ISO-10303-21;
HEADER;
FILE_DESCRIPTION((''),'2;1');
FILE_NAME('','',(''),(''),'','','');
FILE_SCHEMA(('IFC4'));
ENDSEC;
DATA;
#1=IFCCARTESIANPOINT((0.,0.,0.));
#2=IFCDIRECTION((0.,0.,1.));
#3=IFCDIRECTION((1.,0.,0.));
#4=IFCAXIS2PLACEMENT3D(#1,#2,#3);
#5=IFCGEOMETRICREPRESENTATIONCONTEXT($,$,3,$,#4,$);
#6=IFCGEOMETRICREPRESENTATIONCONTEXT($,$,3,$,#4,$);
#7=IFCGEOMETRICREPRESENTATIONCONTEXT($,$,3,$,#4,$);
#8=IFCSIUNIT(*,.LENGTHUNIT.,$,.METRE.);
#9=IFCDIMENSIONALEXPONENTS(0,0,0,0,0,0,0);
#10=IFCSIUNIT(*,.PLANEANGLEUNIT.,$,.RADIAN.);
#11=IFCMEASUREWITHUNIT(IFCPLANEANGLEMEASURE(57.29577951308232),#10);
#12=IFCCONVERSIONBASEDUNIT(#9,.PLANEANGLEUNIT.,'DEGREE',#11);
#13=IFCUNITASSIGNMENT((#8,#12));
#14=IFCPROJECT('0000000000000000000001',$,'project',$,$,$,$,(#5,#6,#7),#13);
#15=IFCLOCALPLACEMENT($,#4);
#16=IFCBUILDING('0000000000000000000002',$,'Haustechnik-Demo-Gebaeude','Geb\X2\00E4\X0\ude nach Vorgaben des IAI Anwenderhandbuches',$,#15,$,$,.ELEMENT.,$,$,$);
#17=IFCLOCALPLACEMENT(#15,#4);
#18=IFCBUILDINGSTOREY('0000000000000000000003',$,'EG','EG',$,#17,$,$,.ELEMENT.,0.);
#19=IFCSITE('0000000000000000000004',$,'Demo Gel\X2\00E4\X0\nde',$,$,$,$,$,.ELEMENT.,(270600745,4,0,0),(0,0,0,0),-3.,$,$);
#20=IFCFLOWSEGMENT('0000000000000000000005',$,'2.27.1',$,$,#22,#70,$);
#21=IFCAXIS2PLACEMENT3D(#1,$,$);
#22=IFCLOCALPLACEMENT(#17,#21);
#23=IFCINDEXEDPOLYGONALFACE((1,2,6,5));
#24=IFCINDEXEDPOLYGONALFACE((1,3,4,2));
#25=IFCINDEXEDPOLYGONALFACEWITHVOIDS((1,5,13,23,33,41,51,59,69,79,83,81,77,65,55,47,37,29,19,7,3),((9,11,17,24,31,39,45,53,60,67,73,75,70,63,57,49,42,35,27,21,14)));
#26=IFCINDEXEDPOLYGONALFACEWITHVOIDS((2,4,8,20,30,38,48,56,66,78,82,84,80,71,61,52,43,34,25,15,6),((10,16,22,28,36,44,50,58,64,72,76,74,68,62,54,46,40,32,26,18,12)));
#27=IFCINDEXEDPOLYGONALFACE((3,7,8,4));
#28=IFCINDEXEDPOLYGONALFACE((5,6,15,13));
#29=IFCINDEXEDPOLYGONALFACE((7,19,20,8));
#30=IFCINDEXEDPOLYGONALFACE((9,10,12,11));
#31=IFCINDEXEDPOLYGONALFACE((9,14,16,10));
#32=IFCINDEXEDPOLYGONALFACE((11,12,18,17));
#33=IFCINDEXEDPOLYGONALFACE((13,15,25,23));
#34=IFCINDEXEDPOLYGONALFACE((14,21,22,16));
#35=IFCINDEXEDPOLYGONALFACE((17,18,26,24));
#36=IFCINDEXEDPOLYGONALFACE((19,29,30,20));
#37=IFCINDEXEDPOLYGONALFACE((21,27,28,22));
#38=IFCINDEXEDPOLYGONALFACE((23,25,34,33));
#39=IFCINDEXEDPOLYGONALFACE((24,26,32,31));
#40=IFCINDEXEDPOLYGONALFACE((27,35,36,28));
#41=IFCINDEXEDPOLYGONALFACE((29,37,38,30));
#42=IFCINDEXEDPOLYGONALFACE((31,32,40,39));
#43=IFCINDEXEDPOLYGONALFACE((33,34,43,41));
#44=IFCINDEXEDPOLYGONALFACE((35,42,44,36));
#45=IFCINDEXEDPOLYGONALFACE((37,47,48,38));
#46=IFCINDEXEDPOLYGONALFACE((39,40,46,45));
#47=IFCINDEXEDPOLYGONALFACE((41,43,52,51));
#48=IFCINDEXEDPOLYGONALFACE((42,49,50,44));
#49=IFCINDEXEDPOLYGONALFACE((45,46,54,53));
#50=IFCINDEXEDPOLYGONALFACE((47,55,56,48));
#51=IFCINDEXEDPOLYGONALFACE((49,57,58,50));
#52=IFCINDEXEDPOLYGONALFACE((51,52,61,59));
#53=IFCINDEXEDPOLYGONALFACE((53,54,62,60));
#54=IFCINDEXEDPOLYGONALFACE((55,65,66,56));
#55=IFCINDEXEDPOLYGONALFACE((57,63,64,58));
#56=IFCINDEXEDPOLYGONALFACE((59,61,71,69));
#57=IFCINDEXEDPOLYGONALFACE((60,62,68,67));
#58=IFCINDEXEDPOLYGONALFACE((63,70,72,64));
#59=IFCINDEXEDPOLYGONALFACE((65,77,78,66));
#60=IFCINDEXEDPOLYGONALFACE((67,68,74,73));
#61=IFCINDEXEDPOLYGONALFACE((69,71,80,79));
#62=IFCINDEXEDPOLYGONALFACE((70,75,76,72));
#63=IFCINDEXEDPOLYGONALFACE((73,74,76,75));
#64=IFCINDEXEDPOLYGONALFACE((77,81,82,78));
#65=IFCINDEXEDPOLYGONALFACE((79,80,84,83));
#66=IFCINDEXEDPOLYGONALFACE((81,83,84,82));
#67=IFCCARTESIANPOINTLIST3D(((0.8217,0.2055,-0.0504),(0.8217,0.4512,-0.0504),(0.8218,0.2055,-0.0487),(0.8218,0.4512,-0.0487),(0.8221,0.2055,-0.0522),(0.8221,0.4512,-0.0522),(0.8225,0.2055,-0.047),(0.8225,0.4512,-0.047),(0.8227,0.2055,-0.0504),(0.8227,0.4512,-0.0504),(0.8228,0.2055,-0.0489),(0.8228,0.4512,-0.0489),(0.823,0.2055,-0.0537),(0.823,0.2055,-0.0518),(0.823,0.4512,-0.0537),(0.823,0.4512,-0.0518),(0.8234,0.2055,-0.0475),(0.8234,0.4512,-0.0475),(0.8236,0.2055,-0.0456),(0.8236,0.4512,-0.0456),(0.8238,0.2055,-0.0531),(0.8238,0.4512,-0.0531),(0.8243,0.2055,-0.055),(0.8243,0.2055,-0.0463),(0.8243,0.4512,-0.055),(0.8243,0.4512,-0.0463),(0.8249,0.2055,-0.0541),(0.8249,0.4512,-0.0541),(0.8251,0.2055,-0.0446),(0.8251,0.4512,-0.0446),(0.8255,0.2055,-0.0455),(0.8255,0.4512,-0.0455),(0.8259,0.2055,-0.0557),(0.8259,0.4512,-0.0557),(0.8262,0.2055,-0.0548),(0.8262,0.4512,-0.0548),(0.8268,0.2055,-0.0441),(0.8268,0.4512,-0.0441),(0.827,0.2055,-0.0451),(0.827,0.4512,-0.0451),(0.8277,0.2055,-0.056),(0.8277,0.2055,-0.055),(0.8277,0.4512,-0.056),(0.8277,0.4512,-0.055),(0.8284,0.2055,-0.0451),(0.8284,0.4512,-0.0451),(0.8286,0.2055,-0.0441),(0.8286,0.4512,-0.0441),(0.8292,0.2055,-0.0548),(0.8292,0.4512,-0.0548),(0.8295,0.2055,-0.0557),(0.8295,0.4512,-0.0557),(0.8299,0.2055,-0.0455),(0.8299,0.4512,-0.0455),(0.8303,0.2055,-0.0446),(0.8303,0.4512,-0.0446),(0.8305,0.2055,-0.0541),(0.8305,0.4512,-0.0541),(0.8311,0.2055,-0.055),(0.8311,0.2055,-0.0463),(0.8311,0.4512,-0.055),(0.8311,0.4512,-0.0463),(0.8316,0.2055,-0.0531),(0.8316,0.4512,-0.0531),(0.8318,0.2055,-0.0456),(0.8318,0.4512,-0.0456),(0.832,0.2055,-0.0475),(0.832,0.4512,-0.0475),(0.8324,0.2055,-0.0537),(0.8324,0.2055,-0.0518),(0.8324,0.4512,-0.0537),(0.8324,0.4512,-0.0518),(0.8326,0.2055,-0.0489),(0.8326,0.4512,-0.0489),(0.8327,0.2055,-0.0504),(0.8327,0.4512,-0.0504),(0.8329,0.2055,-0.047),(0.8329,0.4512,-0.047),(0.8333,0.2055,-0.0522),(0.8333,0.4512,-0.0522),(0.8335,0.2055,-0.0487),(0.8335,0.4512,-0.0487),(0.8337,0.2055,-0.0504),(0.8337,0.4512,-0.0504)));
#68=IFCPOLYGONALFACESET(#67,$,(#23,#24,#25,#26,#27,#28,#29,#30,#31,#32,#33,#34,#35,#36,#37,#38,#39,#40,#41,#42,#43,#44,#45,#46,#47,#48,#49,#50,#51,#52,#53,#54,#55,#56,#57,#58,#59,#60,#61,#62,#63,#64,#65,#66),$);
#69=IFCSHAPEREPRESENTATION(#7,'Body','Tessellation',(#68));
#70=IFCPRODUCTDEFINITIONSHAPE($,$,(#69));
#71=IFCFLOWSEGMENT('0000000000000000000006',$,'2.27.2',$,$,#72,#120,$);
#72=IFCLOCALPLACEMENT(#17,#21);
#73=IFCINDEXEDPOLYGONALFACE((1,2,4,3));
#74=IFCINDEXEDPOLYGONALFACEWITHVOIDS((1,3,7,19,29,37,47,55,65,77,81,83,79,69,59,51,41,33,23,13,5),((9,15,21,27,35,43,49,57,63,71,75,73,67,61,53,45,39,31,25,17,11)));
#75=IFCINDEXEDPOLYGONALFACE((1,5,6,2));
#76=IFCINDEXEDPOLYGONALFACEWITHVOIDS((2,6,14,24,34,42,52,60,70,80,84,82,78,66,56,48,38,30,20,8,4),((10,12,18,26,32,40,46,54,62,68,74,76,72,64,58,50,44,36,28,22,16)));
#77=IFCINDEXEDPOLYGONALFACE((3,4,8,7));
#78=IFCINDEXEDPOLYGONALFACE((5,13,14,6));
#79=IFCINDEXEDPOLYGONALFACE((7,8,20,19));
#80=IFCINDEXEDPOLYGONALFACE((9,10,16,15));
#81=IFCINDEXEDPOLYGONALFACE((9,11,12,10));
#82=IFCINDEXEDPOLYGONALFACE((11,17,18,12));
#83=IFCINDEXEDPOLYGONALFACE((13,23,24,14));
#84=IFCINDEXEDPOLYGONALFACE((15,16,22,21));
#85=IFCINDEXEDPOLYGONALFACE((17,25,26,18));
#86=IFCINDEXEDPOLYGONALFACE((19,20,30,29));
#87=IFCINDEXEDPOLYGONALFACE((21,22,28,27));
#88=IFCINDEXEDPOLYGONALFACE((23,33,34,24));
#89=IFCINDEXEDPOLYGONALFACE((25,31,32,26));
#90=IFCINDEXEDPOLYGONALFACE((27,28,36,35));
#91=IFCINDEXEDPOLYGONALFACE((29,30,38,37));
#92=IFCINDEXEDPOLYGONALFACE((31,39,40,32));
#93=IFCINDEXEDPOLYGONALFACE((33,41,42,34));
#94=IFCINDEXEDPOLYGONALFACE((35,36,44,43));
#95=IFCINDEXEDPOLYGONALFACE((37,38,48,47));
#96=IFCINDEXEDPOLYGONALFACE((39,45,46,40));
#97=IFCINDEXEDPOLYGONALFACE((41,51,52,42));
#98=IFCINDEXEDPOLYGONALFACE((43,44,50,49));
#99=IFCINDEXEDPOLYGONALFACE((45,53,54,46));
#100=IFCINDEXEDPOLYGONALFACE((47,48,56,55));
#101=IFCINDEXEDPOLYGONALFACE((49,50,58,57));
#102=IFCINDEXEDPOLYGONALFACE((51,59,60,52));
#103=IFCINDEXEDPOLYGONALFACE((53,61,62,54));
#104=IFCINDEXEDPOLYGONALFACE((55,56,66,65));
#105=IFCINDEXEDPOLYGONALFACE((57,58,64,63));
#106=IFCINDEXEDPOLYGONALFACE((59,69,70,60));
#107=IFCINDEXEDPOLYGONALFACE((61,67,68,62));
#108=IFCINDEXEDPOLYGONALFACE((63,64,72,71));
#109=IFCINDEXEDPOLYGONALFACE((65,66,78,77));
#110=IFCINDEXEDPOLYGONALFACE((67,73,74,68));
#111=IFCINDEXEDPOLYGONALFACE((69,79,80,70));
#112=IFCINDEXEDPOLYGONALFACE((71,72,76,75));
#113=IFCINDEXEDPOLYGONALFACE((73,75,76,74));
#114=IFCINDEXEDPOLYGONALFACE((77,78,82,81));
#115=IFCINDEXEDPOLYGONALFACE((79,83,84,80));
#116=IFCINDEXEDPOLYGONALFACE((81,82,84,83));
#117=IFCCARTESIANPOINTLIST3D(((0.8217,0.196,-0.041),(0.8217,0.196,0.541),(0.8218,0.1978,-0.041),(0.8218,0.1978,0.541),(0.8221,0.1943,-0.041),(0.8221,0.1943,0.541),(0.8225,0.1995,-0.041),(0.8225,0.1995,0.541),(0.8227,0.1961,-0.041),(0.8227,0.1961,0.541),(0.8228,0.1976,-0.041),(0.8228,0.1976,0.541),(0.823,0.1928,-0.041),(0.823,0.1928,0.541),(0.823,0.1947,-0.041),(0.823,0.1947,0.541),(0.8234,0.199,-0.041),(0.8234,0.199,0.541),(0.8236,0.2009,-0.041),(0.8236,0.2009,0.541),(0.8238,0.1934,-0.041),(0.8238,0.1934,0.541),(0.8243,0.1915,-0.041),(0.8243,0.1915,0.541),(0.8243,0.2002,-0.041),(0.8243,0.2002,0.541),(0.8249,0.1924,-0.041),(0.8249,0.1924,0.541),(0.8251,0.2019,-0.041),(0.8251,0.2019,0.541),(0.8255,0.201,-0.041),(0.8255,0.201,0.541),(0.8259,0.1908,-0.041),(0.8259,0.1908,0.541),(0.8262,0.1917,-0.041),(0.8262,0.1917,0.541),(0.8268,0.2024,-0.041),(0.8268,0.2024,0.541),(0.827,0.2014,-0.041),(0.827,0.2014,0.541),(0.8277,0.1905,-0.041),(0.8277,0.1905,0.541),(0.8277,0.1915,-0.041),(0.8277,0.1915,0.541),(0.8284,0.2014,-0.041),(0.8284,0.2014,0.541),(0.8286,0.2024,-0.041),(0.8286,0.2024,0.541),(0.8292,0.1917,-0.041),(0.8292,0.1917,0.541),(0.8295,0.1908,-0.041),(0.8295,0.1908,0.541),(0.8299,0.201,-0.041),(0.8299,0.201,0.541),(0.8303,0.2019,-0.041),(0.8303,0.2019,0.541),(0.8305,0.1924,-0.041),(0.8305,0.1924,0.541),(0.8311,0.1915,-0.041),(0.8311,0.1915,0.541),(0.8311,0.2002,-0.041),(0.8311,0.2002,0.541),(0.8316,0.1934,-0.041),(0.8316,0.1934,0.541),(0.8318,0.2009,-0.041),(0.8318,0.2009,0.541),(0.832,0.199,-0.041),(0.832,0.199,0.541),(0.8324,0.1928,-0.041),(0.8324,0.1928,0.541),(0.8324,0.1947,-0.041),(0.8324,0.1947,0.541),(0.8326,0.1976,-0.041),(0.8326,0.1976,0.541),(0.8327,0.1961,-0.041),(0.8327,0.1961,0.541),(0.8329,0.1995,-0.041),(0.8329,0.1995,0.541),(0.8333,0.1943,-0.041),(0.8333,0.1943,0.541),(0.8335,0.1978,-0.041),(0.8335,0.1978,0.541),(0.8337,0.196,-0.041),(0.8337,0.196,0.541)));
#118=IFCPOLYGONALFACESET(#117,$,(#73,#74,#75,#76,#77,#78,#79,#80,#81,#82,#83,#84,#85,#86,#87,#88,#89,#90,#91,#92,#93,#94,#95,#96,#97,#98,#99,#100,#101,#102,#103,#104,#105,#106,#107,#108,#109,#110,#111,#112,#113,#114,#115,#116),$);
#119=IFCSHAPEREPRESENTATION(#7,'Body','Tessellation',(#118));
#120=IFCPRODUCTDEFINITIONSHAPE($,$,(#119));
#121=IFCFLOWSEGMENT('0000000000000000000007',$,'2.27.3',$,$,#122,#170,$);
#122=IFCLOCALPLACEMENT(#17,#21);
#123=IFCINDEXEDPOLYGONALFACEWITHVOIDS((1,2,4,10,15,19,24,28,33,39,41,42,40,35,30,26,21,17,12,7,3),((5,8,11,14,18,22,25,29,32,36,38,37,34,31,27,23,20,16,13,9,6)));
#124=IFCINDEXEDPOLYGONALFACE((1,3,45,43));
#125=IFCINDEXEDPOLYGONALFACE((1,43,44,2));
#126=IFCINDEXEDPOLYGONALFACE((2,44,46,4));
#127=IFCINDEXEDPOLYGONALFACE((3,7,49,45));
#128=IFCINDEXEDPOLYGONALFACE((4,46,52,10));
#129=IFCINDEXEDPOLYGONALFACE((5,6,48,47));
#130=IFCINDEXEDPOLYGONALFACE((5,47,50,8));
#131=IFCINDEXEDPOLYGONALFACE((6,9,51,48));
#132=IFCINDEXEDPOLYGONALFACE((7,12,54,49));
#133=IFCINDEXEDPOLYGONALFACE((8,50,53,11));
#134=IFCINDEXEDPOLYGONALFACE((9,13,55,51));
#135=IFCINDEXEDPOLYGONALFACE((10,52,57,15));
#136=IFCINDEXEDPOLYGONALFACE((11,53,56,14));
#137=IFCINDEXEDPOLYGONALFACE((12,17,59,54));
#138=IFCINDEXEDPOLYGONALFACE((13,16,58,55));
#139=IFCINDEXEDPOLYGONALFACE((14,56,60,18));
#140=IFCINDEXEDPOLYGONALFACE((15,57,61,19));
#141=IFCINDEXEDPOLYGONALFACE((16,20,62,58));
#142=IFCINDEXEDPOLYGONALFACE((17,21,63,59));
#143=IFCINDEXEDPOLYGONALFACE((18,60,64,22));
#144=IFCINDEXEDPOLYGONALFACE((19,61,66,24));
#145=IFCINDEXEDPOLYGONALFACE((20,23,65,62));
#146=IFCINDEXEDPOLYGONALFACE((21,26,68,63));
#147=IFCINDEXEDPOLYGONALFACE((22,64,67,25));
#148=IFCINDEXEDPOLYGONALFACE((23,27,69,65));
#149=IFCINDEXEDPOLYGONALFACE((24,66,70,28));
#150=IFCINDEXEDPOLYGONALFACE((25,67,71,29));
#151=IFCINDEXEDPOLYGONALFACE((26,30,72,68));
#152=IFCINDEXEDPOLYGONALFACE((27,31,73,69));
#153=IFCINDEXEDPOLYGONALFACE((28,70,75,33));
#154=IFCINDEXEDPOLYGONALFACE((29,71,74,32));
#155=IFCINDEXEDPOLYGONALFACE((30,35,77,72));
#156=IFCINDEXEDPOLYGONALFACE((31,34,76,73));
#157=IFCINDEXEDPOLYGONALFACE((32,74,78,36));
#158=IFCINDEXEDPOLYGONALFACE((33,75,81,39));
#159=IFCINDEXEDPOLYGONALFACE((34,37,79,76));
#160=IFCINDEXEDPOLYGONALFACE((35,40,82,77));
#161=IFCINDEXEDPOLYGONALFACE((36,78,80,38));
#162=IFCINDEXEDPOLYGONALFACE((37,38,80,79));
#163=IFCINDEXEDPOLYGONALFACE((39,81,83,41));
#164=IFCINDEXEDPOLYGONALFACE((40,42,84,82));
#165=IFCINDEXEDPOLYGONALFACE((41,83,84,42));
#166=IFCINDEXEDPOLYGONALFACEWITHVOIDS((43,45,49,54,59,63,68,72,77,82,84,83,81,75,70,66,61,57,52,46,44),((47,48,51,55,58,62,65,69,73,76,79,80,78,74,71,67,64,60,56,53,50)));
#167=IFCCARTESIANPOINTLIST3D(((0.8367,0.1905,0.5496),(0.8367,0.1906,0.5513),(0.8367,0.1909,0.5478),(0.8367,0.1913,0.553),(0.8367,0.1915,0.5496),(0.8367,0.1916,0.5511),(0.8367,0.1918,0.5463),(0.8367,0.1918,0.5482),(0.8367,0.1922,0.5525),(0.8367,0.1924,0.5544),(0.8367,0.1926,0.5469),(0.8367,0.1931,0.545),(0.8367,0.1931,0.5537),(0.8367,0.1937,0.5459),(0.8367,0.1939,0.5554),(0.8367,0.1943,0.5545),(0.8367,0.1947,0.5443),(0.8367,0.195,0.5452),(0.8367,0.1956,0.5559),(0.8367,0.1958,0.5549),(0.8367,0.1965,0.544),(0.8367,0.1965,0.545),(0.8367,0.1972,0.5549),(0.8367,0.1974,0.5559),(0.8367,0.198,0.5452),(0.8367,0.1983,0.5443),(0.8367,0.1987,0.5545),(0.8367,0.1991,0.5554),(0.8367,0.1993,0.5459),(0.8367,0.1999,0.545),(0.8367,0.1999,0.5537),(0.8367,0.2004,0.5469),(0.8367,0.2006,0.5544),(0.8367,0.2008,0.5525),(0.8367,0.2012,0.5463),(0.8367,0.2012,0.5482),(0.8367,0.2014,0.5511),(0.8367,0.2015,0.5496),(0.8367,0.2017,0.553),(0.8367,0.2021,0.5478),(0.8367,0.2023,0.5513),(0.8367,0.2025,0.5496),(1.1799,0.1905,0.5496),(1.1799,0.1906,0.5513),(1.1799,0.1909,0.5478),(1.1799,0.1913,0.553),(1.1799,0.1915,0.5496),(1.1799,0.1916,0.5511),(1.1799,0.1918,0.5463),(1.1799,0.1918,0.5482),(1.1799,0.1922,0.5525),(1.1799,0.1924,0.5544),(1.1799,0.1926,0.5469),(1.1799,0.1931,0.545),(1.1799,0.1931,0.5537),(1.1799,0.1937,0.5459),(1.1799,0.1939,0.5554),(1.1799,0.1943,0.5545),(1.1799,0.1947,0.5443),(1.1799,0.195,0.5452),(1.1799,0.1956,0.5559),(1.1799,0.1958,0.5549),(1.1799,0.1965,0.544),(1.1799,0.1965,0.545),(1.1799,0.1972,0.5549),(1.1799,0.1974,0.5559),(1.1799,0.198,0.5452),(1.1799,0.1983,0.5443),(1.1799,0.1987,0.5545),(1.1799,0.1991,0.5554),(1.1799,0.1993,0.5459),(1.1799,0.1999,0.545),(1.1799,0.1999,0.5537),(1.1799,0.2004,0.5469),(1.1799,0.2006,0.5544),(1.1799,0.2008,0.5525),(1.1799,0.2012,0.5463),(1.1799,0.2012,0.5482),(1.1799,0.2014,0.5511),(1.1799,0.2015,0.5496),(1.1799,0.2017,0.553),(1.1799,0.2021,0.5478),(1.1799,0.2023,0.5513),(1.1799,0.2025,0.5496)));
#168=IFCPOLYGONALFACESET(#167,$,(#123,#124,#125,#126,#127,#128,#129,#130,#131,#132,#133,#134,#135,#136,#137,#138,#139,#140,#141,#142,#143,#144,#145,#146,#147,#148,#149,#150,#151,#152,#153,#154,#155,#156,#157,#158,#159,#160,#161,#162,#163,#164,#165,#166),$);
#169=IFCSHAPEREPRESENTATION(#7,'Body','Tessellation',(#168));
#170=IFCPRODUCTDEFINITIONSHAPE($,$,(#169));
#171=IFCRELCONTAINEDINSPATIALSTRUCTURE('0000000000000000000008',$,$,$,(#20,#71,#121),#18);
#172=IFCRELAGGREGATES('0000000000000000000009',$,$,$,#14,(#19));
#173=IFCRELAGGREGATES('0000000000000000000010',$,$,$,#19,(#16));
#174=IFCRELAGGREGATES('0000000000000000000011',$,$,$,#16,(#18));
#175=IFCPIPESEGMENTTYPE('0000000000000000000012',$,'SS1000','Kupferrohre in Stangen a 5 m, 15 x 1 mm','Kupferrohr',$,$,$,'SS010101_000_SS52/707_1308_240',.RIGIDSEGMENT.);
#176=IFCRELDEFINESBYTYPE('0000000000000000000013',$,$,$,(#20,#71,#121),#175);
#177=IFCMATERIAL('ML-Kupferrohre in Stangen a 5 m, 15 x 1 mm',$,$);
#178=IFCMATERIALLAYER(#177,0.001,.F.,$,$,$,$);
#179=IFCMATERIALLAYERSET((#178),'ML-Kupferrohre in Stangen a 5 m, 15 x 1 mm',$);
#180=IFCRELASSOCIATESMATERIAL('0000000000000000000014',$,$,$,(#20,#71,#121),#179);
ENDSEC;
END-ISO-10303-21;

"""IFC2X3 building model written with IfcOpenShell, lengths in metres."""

from ifc_helpers import new_model, entity, si_unit, converted_unit, frame, origin_with_axes, origin_2d_with_axis, place, context, project, spatial, hollow_circle, extrude, material, layer, layer_set, layer_usage, type_object, element, save


model = new_model("IFC2X3")

# Units and contexts
context_of_model_1 = context(None, 3, world=origin_with_axes())
context_of_model_2 = context(None, 3, world=origin_with_axes())
context_of_model_3 = context(None, 3, world=origin_with_axes())
ifc_project = project(units=[si_unit("LENGTHUNIT", "METRE"), converted_unit("PLANEANGLEUNIT", "DEGREE", entity("IfcPlaneAngleMeasure", 57.29577951308232), si_unit("PLANEANGLEUNIT", "RADIAN"), dimensions=[0, 0, 0, 0, 0, 0, 0])], contexts=[context_of_model_1, context_of_model_2, context_of_model_3])

# Site, building, storey
site = spatial("IfcSite", under=ifc_project, Name="Demo Gelände", CompositionType="ELEMENT", RefLatitude=(270600745, 4, 0, 0), RefLongitude=(0, 0, 0, 0), RefElevation=-3.0)
building_placement = place(None, origin_with_axes())
building = spatial("IfcBuilding", under=site, at=building_placement, Name="Haustechnik-Demo-Gebaeude", Description="Gebäude nach Vorgaben des IAI Anwenderhandbuches", CompositionType="ELEMENT")
storey_placement = place(building_placement, origin_with_axes())
storey = spatial("IfcBuildingStorey", under=building, at=storey_placement, Name="EG", Description="EG", CompositionType="ELEMENT", Elevation=0.0)

# Flow segments
ifc_material = material(Name="ML-Kupferrohre in Stangen a 5 m, 15 x 1 mm")
ifc_layer = layer(ifc_material, 0.001, ventilated=False)
ifc_layer_set = layer_set([ifc_layer], Name="ML-Kupferrohre in Stangen a 5 m, 15 x 1 mm")
ifc_layer_usage = layer_usage(ifc_layer_set, "AXIS2", "POSITIVE", 0.0)
pipe_segment_type_1 = type_object("IfcPipeSegmentType", Name="SS1000", Description="Kupferrohre in Stangen a 5 m, 15 x 1 mm", ApplicableOccurrence="Kupferrohr", ElementType="SS010101_000_SS52/707_1308_240", PredefinedType="RIGIDSEGMENT")
flow_segment_1_placement = place(storey_placement, frame((0.8277, 0.4512, -0.05), z_axis=(0.0, -1.0, 0.0), x_axis=(0.0, 0.0, -1.0)))
element("IfcFlowSegment", 1, at=flow_segment_1_placement, inside=storey, type_object=pipe_segment_type_1, material=ifc_layer_usage, Name="2.27.1", context=context_of_model_3, shape_type="SweptSolid", body=[
    extrude(hollow_circle(Radius=0.006, WallThickness=0.001, at=origin_2d_with_axis()), origin_with_axes(), (0.0, 0.0, 1.0), 0.2457),
])
flow_segment_2_placement = place(storey_placement, frame((0.8277, 0.1965, -0.041), z_axis=(0.0, 0.0, 1.0), x_axis=(0.0, -1.0, 0.0)))
element("IfcFlowSegment", 2, at=flow_segment_2_placement, inside=storey, type_object=pipe_segment_type_1, material=ifc_layer_usage, Name="2.27.2", context=context_of_model_3, shape_type="SweptSolid", body=[
    extrude(hollow_circle(Radius=0.006, WallThickness=0.001, at=origin_2d_with_axis()), origin_with_axes(), (0.0, 0.0, 1.0), 0.582),
])
flow_segment_3_placement = place(storey_placement, frame((0.8367, 0.1965, 0.55), z_axis=(1.0, 0.0, 0.0), x_axis=(0.0, 0.0, -1.0)))
element("IfcFlowSegment", 3, at=flow_segment_3_placement, inside=storey, type_object=pipe_segment_type_1, material=ifc_layer_usage, Name="2.27.3", context=context_of_model_3, shape_type="SweptSolid", body=[
    extrude(hollow_circle(Radius=0.006, WallThickness=0.001, at=origin_2d_with_axis()), origin_with_axes(), (0.0, 0.0, 1.0), 0.3433),
])

save(model, "model.ifc")
